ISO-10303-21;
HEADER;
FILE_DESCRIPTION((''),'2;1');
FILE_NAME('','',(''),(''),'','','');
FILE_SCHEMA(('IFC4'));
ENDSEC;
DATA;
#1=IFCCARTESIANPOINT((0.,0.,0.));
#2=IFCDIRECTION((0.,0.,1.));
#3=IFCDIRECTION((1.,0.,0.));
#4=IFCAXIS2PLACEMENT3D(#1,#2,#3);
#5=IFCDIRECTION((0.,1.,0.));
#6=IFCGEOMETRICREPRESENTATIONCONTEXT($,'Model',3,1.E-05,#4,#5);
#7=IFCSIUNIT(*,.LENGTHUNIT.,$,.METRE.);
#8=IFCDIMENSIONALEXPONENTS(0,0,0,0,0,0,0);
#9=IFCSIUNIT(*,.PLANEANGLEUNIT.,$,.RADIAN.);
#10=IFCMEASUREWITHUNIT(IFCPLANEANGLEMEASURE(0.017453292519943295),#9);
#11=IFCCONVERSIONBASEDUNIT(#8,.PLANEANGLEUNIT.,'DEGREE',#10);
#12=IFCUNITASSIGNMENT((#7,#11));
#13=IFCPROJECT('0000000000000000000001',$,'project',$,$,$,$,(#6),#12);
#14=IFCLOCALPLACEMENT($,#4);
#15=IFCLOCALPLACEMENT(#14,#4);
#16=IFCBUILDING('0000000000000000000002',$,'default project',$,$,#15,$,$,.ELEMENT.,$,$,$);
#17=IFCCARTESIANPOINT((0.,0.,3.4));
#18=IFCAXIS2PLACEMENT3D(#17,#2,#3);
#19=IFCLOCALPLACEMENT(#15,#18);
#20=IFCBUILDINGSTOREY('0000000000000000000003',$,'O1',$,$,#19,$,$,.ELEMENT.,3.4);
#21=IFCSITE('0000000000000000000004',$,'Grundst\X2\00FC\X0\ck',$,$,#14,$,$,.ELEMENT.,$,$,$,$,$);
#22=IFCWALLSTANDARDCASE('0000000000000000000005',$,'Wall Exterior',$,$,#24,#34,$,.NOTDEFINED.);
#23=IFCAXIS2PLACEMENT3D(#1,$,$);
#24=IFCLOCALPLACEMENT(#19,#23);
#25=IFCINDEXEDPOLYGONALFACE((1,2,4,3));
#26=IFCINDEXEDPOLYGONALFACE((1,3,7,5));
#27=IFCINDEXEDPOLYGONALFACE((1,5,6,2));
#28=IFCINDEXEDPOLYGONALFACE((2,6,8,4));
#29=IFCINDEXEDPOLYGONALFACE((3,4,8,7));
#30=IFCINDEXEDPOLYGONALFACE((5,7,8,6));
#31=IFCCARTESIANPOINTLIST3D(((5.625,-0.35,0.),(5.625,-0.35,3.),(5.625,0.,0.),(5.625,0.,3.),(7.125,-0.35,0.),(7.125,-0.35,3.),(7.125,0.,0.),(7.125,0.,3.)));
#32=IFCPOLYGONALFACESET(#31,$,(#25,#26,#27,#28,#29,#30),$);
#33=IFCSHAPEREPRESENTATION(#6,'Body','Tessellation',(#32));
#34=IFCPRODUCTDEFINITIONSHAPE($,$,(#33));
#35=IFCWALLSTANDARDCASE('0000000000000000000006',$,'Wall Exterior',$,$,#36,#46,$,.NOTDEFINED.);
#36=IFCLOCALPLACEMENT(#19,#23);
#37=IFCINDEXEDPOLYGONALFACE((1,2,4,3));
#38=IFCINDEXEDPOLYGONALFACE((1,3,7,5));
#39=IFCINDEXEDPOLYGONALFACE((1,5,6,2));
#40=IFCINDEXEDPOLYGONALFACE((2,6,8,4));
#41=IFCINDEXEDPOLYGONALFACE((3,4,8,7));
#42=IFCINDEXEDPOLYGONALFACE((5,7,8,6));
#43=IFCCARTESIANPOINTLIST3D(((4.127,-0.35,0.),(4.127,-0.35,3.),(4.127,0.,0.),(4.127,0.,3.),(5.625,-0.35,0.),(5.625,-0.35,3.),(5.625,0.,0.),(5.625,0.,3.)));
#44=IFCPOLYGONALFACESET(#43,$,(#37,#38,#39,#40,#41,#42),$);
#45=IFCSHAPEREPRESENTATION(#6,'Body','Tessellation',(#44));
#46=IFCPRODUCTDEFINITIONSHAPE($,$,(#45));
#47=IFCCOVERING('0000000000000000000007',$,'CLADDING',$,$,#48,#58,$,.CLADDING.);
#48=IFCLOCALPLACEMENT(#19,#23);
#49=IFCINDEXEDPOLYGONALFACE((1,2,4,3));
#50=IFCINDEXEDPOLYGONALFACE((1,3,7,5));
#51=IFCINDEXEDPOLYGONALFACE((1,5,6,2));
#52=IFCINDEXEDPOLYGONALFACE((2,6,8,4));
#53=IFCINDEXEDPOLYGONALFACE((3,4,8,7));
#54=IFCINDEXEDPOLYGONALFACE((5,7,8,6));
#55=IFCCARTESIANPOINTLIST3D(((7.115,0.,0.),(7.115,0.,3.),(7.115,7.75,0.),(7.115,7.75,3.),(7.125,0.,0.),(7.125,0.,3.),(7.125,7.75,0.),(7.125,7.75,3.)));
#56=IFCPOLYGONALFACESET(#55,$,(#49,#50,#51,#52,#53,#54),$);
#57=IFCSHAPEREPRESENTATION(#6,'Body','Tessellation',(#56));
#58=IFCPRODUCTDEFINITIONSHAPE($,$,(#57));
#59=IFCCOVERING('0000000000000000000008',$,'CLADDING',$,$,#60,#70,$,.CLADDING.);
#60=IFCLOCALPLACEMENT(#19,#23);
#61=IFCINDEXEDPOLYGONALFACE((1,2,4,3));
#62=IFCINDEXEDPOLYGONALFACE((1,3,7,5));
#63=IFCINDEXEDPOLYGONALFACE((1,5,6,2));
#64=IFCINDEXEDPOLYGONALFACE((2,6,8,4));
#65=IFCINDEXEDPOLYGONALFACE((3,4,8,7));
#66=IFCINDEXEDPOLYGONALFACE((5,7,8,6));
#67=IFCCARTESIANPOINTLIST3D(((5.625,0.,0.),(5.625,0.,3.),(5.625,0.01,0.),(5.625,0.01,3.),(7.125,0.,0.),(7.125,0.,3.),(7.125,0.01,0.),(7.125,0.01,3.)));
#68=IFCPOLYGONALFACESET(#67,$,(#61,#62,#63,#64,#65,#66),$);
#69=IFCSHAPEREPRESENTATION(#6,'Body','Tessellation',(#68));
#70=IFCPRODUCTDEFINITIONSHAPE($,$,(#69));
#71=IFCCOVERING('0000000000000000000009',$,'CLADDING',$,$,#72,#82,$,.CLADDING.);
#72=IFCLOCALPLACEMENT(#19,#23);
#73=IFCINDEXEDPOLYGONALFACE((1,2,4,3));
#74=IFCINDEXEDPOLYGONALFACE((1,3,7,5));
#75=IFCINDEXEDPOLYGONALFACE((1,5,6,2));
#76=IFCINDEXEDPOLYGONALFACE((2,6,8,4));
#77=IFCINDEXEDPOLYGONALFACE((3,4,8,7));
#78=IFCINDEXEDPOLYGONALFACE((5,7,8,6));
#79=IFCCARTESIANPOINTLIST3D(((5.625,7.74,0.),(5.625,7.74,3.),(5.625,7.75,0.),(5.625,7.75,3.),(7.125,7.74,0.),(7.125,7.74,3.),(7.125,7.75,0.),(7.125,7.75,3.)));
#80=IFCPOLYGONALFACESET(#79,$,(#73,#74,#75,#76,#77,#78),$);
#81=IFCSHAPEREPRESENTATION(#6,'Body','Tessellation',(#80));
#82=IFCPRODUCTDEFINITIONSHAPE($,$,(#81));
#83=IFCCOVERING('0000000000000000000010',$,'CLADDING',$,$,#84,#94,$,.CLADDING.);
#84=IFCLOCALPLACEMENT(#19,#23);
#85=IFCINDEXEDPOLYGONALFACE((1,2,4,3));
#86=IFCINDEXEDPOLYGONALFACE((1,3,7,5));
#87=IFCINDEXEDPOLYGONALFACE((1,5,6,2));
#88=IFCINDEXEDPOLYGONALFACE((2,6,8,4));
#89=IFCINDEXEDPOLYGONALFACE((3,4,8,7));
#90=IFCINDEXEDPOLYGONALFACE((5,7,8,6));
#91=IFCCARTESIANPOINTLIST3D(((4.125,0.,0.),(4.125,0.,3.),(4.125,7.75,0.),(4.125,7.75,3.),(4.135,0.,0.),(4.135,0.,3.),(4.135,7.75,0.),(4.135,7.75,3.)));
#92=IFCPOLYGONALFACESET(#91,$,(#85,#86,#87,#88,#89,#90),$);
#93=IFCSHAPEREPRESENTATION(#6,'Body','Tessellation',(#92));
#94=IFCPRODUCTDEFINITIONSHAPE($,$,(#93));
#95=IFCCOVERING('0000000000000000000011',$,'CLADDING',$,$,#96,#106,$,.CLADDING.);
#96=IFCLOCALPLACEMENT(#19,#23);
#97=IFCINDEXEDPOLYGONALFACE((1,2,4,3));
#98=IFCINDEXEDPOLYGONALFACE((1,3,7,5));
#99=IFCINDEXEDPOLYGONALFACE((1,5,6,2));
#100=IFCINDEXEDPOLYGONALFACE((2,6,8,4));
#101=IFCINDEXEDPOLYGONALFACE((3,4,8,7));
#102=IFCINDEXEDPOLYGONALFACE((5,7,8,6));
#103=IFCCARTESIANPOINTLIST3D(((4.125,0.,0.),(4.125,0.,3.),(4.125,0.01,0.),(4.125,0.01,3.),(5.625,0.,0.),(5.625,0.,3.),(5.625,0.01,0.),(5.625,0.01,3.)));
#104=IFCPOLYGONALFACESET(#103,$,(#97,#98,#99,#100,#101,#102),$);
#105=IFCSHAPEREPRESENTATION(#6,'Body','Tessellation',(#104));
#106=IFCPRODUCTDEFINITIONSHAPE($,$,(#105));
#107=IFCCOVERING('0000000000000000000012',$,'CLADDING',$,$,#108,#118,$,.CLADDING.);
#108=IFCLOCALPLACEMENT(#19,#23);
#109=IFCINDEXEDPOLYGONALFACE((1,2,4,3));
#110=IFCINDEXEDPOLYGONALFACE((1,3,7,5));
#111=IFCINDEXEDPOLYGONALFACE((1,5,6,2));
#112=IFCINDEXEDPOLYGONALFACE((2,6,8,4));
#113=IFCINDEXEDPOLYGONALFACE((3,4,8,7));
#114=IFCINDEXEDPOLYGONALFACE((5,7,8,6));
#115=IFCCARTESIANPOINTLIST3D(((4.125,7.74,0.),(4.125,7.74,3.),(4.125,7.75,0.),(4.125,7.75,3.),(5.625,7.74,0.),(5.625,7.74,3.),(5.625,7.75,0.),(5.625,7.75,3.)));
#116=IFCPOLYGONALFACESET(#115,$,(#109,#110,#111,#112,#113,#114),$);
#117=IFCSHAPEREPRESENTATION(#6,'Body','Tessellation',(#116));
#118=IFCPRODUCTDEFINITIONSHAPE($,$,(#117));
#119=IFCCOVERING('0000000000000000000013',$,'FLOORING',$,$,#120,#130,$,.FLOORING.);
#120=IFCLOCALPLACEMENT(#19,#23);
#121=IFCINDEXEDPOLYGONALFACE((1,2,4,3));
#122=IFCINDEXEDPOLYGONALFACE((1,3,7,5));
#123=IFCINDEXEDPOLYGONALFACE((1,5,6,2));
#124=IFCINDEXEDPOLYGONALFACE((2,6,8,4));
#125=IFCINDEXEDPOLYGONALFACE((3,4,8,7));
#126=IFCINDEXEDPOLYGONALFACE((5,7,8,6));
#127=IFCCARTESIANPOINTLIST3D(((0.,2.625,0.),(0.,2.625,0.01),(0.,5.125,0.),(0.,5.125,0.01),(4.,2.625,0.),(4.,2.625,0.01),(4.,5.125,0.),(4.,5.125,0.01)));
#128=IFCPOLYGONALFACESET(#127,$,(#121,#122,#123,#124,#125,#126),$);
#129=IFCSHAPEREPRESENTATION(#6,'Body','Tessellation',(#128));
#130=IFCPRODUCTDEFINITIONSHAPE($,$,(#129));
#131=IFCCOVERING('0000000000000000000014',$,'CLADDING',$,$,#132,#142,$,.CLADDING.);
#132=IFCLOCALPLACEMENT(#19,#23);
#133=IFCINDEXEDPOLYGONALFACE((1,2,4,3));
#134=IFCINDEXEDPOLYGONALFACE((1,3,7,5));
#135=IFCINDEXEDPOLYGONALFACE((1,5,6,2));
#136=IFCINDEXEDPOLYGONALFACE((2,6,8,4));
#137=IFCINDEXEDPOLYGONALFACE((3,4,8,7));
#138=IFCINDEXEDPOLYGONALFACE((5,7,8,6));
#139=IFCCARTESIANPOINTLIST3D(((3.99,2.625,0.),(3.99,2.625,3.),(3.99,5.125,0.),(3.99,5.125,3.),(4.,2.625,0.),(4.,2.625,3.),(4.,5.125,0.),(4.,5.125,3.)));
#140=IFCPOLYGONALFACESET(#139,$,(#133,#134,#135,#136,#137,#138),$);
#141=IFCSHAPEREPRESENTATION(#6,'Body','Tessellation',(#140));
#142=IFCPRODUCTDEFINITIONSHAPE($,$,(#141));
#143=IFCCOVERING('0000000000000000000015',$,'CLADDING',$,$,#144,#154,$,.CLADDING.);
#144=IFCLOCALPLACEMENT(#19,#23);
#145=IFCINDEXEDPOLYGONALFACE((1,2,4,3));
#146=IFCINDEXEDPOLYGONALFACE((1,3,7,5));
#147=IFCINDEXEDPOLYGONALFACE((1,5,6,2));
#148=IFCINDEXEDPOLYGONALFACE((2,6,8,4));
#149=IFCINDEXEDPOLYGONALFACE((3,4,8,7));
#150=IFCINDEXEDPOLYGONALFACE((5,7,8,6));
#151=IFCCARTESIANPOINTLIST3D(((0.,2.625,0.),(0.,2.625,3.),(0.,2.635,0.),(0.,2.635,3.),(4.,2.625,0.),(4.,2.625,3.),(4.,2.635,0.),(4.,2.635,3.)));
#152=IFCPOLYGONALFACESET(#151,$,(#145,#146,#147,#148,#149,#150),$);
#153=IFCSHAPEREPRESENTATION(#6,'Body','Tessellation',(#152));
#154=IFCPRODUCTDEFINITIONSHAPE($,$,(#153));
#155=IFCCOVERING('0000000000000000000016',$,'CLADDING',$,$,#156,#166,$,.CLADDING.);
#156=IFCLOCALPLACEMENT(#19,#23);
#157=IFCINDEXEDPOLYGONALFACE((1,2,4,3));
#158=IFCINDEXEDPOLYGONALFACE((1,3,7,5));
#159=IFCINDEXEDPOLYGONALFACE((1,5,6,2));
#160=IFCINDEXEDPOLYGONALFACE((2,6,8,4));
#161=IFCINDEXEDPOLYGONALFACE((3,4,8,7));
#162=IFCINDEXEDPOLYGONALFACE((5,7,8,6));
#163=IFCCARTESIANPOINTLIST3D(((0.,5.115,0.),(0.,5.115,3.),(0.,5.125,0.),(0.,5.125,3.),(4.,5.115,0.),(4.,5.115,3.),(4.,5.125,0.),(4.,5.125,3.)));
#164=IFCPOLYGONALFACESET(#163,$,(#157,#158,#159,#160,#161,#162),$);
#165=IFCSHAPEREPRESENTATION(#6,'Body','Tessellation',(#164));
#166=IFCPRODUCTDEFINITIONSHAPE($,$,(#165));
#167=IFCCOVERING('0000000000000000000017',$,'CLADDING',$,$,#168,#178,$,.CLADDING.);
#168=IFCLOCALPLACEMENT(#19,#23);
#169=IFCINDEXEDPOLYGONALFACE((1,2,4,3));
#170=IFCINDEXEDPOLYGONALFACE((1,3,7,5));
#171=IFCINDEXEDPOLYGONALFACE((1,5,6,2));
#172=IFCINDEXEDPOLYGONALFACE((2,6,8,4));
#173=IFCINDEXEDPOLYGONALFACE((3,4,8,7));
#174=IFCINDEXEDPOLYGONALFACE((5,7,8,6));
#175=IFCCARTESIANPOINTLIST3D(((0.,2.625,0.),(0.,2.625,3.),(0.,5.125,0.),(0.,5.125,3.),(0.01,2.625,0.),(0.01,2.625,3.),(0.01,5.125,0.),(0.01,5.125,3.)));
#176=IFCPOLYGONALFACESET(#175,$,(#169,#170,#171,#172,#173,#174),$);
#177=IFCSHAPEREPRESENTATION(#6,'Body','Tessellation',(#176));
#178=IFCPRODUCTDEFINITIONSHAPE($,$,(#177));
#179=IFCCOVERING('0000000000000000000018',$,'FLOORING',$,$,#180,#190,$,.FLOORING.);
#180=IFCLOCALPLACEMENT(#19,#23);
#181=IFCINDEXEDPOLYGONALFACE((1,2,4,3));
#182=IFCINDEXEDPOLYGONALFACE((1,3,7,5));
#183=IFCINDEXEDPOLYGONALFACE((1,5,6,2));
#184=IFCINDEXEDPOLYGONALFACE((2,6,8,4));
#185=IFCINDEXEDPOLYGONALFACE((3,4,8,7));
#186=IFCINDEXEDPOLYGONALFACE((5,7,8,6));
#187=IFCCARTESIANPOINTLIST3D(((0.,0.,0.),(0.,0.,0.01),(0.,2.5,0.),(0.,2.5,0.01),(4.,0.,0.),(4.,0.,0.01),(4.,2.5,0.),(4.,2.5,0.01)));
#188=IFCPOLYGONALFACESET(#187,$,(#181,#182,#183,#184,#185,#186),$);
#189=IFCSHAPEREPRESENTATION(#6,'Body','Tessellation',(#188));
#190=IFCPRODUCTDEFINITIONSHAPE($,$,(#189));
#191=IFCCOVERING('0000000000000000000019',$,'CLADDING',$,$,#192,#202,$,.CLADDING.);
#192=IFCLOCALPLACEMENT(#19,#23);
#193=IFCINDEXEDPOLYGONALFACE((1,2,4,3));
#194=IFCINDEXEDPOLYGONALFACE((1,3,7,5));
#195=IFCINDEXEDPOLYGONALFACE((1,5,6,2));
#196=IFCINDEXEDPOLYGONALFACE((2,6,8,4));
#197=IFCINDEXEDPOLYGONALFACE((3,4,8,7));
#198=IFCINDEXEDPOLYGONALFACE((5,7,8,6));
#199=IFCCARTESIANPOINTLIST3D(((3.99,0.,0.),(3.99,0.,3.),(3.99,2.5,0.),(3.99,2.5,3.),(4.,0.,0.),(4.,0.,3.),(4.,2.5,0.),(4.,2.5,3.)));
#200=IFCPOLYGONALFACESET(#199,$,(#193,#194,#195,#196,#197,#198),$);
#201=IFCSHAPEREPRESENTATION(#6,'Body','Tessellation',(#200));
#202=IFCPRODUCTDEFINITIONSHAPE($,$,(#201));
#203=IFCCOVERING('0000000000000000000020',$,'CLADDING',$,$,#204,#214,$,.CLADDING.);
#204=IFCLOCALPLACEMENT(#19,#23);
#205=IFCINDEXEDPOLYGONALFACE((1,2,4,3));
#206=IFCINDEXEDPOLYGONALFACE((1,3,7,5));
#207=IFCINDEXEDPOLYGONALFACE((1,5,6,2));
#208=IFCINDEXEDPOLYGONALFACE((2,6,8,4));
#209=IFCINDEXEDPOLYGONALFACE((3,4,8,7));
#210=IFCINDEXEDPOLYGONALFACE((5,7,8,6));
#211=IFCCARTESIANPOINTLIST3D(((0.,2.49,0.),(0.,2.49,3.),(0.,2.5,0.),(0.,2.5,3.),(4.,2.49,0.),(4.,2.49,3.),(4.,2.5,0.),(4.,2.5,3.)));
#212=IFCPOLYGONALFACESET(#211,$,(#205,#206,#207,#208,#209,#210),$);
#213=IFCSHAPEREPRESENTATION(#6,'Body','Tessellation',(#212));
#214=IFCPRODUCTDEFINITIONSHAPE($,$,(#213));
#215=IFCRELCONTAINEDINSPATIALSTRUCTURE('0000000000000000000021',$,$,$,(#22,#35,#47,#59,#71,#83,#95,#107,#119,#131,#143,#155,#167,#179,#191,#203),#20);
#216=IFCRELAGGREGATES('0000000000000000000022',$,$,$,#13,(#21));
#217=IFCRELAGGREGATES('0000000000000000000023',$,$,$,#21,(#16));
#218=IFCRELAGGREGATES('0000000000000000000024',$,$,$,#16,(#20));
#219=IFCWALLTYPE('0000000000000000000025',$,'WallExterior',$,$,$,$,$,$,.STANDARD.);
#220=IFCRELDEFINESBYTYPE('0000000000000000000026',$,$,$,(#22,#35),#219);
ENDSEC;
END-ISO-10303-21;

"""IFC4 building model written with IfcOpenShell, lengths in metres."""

from ifc_helpers import new_model, entity, si_unit, converted_unit, direction, frame, origin_with_axes, place, context, project, spatial, polyline, outline, extrude, type_object, element, save


model = new_model("IFC4")

# Units and contexts
model_context = context("Model", 3, precision=1e-05, world=origin_with_axes(), true_north=direction((0.0, 1.0, 0.0)))
ifc_project = project(units=[si_unit("LENGTHUNIT", "METRE"), converted_unit("PLANEANGLEUNIT", "DEGREE", entity("IfcPlaneAngleMeasure", 0.017453292519943295), si_unit("PLANEANGLEUNIT", "RADIAN"), dimensions=[0, 0, 0, 0, 0, 0, 0])], contexts=[model_context])

# Site, building, storey
site_placement = place(None, origin_with_axes())
site = spatial("IfcSite", under=ifc_project, at=site_placement, Name="Grundstück", CompositionType="ELEMENT")
building_placement = place(site_placement, origin_with_axes())
building = spatial("IfcBuilding", under=site, at=building_placement, Name="default project", CompositionType="ELEMENT")
placement_1 = place(building_placement, frame((0.0, 0.0, 3.4), z_axis=(0.0, 0.0, 1.0), x_axis=(1.0, 0.0, 0.0)))
storey = spatial("IfcBuildingStorey", under=building, at=placement_1, Name="O1", CompositionType="ELEMENT", Elevation=3.4)

# Walls
wall_type_1 = type_object("IfcWallType", Name="WallExterior", PredefinedType="STANDARD")
placement_2 = place(placement_1, frame((7.3, -0.175, 0.0), z_axis=(0.0, 0.0, 1.0), x_axis=(-1.0, 0.0, 0.0)))
element("IfcWallStandardCase", 1, at=placement_2, inside=storey, type_object=wall_type_1, Name="Wall Exterior", PredefinedType="NOTDEFINED", context=model_context, shape_type="SweptSolid", body=[
    extrude(outline(polyline([(0.175, -0.175), (1.675, -0.175), (1.675, 0.175), (0.175, 0.175), (0.175, -0.175)])), origin_with_axes(), (0.0, 0.0, 1.0), 3.0),
])
placement_3 = place(placement_1, frame((5.625, -0.175, 0.0), z_axis=(0.0, 0.0, 1.0), x_axis=(-1.0, 0.0, 0.0)))
element("IfcWallStandardCase", 2, at=placement_3, inside=storey, type_object=wall_type_1, Name="Wall Exterior", PredefinedType="NOTDEFINED", context=model_context, shape_type="SweptSolid", body=[
    extrude(outline(polyline([(0.0, -0.175), (1.498, -0.175), (1.498, 0.175), (0.0, 0.175), (0.0, -0.175)])), origin_with_axes(), (0.0, 0.0, 1.0), 3.0),
])

# Coverings
element("IfcCovering", 3, at=placement_1, inside=storey, Name="CLADDING", PredefinedType="CLADDING", context=model_context, shape_type="SweptSolid", body=[
    extrude(outline(polyline([(7.115, 7.75), (7.115, 0.0), (7.125, 0.0), (7.125, 7.75), (7.115, 7.75)])), origin_with_axes(), (0.0, 0.0, 1.0), 3.0),
])
element("IfcCovering", 4, at=placement_1, inside=storey, Name="CLADDING", PredefinedType="CLADDING", context=model_context, shape_type="SweptSolid", body=[
    extrude(outline(polyline([(7.125, 0.01), (5.625, 0.01), (5.625, 0.0), (7.125, 0.0), (7.125, 0.01)])), origin_with_axes(), (0.0, 0.0, 1.0), 3.0),
])
element("IfcCovering", 5, at=placement_1, inside=storey, Name="CLADDING", PredefinedType="CLADDING", context=model_context, shape_type="SweptSolid", body=[
    extrude(outline(polyline([(5.625, 7.74), (7.125, 7.74), (7.125, 7.75), (5.625, 7.75), (5.625, 7.74)])), origin_with_axes(), (0.0, 0.0, 1.0), 3.0),
])
element("IfcCovering", 6, at=placement_1, inside=storey, Name="CLADDING", PredefinedType="CLADDING", context=model_context, shape_type="SweptSolid", body=[
    extrude(outline(polyline([(4.135, 0.0), (4.135, 7.75), (4.125, 7.75), (4.125, 0.0), (4.135, 0.0)])), origin_with_axes(), (0.0, 0.0, 1.0), 3.0),
])
element("IfcCovering", 7, at=placement_1, inside=storey, Name="CLADDING", PredefinedType="CLADDING", context=model_context, shape_type="SweptSolid", body=[
    extrude(outline(polyline([(5.625, 0.01), (4.125, 0.01), (4.125, 0.0), (5.625, 0.0), (5.625, 0.01)])), origin_with_axes(), (0.0, 0.0, 1.0), 3.0),
])
element("IfcCovering", 8, at=placement_1, inside=storey, Name="CLADDING", PredefinedType="CLADDING", context=model_context, shape_type="SweptSolid", body=[
    extrude(outline(polyline([(4.125, 7.74), (5.625, 7.74), (5.625, 7.75), (4.125, 7.75), (4.125, 7.74)])), origin_with_axes(), (0.0, 0.0, 1.0), 3.0),
])
element("IfcCovering", 9, at=placement_1, inside=storey, Name="FLOORING", PredefinedType="FLOORING", context=model_context, shape_type="SweptSolid", body=[
    extrude(outline(polyline([(4.0, 5.125), (0.0, 5.125), (0.0, 2.625), (4.0, 2.625), (4.0, 5.125)])), origin_with_axes(), (0.0, 0.0, 1.0), 0.01),
])
element("IfcCovering", 10, at=placement_1, inside=storey, Name="CLADDING", PredefinedType="CLADDING", context=model_context, shape_type="SweptSolid", body=[
    extrude(outline(polyline([(3.99, 5.125), (3.99, 2.625), (4.0, 2.625), (4.0, 5.125), (3.99, 5.125)])), origin_with_axes(), (0.0, 0.0, 1.0), 3.0),
])
element("IfcCovering", 11, at=placement_1, inside=storey, Name="CLADDING", PredefinedType="CLADDING", context=model_context, shape_type="SweptSolid", body=[
    extrude(outline(polyline([(4.0, 2.635), (0.0, 2.635), (0.0, 2.625), (4.0, 2.625), (4.0, 2.635)])), origin_with_axes(), (0.0, 0.0, 1.0), 3.0),
])
element("IfcCovering", 12, at=placement_1, inside=storey, Name="CLADDING", PredefinedType="CLADDING", context=model_context, shape_type="SweptSolid", body=[
    extrude(outline(polyline([(0.0, 5.115), (4.0, 5.115), (4.0, 5.125), (0.0, 5.125), (0.0, 5.115)])), origin_with_axes(), (0.0, 0.0, 1.0), 3.0),
])
element("IfcCovering", 13, at=placement_1, inside=storey, Name="CLADDING", PredefinedType="CLADDING", context=model_context, shape_type="SweptSolid", body=[
    extrude(outline(polyline([(0.01, 2.625), (0.01, 5.125), (0.0, 5.125), (0.0, 2.625), (0.01, 2.625)])), origin_with_axes(), (0.0, 0.0, 1.0), 3.0),
])
element("IfcCovering", 14, at=placement_1, inside=storey, Name="FLOORING", PredefinedType="FLOORING", context=model_context, shape_type="SweptSolid", body=[
    extrude(outline(polyline([(4.0, 2.5), (0.0, 2.5), (0.0, 0.0), (4.0, 0.0), (4.0, 2.5)])), origin_with_axes(), (0.0, 0.0, 1.0), 0.01),
])
element("IfcCovering", 15, at=placement_1, inside=storey, Name="CLADDING", PredefinedType="CLADDING", context=model_context, shape_type="SweptSolid", body=[
    extrude(outline(polyline([(3.99, 2.5), (3.99, 0.0), (4.0, 0.0), (4.0, 2.5), (3.99, 2.5)])), origin_with_axes(), (0.0, 0.0, 1.0), 3.0),
])
element("IfcCovering", 16, at=placement_1, inside=storey, Name="CLADDING", PredefinedType="CLADDING", context=model_context, shape_type="SweptSolid", body=[
    extrude(outline(polyline([(0.0, 2.49), (4.0, 2.49), (4.0, 2.5), (0.0, 2.5), (0.0, 2.49)])), origin_with_axes(), (0.0, 0.0, 1.0), 3.0),
])

save(model, "model.ifc")
